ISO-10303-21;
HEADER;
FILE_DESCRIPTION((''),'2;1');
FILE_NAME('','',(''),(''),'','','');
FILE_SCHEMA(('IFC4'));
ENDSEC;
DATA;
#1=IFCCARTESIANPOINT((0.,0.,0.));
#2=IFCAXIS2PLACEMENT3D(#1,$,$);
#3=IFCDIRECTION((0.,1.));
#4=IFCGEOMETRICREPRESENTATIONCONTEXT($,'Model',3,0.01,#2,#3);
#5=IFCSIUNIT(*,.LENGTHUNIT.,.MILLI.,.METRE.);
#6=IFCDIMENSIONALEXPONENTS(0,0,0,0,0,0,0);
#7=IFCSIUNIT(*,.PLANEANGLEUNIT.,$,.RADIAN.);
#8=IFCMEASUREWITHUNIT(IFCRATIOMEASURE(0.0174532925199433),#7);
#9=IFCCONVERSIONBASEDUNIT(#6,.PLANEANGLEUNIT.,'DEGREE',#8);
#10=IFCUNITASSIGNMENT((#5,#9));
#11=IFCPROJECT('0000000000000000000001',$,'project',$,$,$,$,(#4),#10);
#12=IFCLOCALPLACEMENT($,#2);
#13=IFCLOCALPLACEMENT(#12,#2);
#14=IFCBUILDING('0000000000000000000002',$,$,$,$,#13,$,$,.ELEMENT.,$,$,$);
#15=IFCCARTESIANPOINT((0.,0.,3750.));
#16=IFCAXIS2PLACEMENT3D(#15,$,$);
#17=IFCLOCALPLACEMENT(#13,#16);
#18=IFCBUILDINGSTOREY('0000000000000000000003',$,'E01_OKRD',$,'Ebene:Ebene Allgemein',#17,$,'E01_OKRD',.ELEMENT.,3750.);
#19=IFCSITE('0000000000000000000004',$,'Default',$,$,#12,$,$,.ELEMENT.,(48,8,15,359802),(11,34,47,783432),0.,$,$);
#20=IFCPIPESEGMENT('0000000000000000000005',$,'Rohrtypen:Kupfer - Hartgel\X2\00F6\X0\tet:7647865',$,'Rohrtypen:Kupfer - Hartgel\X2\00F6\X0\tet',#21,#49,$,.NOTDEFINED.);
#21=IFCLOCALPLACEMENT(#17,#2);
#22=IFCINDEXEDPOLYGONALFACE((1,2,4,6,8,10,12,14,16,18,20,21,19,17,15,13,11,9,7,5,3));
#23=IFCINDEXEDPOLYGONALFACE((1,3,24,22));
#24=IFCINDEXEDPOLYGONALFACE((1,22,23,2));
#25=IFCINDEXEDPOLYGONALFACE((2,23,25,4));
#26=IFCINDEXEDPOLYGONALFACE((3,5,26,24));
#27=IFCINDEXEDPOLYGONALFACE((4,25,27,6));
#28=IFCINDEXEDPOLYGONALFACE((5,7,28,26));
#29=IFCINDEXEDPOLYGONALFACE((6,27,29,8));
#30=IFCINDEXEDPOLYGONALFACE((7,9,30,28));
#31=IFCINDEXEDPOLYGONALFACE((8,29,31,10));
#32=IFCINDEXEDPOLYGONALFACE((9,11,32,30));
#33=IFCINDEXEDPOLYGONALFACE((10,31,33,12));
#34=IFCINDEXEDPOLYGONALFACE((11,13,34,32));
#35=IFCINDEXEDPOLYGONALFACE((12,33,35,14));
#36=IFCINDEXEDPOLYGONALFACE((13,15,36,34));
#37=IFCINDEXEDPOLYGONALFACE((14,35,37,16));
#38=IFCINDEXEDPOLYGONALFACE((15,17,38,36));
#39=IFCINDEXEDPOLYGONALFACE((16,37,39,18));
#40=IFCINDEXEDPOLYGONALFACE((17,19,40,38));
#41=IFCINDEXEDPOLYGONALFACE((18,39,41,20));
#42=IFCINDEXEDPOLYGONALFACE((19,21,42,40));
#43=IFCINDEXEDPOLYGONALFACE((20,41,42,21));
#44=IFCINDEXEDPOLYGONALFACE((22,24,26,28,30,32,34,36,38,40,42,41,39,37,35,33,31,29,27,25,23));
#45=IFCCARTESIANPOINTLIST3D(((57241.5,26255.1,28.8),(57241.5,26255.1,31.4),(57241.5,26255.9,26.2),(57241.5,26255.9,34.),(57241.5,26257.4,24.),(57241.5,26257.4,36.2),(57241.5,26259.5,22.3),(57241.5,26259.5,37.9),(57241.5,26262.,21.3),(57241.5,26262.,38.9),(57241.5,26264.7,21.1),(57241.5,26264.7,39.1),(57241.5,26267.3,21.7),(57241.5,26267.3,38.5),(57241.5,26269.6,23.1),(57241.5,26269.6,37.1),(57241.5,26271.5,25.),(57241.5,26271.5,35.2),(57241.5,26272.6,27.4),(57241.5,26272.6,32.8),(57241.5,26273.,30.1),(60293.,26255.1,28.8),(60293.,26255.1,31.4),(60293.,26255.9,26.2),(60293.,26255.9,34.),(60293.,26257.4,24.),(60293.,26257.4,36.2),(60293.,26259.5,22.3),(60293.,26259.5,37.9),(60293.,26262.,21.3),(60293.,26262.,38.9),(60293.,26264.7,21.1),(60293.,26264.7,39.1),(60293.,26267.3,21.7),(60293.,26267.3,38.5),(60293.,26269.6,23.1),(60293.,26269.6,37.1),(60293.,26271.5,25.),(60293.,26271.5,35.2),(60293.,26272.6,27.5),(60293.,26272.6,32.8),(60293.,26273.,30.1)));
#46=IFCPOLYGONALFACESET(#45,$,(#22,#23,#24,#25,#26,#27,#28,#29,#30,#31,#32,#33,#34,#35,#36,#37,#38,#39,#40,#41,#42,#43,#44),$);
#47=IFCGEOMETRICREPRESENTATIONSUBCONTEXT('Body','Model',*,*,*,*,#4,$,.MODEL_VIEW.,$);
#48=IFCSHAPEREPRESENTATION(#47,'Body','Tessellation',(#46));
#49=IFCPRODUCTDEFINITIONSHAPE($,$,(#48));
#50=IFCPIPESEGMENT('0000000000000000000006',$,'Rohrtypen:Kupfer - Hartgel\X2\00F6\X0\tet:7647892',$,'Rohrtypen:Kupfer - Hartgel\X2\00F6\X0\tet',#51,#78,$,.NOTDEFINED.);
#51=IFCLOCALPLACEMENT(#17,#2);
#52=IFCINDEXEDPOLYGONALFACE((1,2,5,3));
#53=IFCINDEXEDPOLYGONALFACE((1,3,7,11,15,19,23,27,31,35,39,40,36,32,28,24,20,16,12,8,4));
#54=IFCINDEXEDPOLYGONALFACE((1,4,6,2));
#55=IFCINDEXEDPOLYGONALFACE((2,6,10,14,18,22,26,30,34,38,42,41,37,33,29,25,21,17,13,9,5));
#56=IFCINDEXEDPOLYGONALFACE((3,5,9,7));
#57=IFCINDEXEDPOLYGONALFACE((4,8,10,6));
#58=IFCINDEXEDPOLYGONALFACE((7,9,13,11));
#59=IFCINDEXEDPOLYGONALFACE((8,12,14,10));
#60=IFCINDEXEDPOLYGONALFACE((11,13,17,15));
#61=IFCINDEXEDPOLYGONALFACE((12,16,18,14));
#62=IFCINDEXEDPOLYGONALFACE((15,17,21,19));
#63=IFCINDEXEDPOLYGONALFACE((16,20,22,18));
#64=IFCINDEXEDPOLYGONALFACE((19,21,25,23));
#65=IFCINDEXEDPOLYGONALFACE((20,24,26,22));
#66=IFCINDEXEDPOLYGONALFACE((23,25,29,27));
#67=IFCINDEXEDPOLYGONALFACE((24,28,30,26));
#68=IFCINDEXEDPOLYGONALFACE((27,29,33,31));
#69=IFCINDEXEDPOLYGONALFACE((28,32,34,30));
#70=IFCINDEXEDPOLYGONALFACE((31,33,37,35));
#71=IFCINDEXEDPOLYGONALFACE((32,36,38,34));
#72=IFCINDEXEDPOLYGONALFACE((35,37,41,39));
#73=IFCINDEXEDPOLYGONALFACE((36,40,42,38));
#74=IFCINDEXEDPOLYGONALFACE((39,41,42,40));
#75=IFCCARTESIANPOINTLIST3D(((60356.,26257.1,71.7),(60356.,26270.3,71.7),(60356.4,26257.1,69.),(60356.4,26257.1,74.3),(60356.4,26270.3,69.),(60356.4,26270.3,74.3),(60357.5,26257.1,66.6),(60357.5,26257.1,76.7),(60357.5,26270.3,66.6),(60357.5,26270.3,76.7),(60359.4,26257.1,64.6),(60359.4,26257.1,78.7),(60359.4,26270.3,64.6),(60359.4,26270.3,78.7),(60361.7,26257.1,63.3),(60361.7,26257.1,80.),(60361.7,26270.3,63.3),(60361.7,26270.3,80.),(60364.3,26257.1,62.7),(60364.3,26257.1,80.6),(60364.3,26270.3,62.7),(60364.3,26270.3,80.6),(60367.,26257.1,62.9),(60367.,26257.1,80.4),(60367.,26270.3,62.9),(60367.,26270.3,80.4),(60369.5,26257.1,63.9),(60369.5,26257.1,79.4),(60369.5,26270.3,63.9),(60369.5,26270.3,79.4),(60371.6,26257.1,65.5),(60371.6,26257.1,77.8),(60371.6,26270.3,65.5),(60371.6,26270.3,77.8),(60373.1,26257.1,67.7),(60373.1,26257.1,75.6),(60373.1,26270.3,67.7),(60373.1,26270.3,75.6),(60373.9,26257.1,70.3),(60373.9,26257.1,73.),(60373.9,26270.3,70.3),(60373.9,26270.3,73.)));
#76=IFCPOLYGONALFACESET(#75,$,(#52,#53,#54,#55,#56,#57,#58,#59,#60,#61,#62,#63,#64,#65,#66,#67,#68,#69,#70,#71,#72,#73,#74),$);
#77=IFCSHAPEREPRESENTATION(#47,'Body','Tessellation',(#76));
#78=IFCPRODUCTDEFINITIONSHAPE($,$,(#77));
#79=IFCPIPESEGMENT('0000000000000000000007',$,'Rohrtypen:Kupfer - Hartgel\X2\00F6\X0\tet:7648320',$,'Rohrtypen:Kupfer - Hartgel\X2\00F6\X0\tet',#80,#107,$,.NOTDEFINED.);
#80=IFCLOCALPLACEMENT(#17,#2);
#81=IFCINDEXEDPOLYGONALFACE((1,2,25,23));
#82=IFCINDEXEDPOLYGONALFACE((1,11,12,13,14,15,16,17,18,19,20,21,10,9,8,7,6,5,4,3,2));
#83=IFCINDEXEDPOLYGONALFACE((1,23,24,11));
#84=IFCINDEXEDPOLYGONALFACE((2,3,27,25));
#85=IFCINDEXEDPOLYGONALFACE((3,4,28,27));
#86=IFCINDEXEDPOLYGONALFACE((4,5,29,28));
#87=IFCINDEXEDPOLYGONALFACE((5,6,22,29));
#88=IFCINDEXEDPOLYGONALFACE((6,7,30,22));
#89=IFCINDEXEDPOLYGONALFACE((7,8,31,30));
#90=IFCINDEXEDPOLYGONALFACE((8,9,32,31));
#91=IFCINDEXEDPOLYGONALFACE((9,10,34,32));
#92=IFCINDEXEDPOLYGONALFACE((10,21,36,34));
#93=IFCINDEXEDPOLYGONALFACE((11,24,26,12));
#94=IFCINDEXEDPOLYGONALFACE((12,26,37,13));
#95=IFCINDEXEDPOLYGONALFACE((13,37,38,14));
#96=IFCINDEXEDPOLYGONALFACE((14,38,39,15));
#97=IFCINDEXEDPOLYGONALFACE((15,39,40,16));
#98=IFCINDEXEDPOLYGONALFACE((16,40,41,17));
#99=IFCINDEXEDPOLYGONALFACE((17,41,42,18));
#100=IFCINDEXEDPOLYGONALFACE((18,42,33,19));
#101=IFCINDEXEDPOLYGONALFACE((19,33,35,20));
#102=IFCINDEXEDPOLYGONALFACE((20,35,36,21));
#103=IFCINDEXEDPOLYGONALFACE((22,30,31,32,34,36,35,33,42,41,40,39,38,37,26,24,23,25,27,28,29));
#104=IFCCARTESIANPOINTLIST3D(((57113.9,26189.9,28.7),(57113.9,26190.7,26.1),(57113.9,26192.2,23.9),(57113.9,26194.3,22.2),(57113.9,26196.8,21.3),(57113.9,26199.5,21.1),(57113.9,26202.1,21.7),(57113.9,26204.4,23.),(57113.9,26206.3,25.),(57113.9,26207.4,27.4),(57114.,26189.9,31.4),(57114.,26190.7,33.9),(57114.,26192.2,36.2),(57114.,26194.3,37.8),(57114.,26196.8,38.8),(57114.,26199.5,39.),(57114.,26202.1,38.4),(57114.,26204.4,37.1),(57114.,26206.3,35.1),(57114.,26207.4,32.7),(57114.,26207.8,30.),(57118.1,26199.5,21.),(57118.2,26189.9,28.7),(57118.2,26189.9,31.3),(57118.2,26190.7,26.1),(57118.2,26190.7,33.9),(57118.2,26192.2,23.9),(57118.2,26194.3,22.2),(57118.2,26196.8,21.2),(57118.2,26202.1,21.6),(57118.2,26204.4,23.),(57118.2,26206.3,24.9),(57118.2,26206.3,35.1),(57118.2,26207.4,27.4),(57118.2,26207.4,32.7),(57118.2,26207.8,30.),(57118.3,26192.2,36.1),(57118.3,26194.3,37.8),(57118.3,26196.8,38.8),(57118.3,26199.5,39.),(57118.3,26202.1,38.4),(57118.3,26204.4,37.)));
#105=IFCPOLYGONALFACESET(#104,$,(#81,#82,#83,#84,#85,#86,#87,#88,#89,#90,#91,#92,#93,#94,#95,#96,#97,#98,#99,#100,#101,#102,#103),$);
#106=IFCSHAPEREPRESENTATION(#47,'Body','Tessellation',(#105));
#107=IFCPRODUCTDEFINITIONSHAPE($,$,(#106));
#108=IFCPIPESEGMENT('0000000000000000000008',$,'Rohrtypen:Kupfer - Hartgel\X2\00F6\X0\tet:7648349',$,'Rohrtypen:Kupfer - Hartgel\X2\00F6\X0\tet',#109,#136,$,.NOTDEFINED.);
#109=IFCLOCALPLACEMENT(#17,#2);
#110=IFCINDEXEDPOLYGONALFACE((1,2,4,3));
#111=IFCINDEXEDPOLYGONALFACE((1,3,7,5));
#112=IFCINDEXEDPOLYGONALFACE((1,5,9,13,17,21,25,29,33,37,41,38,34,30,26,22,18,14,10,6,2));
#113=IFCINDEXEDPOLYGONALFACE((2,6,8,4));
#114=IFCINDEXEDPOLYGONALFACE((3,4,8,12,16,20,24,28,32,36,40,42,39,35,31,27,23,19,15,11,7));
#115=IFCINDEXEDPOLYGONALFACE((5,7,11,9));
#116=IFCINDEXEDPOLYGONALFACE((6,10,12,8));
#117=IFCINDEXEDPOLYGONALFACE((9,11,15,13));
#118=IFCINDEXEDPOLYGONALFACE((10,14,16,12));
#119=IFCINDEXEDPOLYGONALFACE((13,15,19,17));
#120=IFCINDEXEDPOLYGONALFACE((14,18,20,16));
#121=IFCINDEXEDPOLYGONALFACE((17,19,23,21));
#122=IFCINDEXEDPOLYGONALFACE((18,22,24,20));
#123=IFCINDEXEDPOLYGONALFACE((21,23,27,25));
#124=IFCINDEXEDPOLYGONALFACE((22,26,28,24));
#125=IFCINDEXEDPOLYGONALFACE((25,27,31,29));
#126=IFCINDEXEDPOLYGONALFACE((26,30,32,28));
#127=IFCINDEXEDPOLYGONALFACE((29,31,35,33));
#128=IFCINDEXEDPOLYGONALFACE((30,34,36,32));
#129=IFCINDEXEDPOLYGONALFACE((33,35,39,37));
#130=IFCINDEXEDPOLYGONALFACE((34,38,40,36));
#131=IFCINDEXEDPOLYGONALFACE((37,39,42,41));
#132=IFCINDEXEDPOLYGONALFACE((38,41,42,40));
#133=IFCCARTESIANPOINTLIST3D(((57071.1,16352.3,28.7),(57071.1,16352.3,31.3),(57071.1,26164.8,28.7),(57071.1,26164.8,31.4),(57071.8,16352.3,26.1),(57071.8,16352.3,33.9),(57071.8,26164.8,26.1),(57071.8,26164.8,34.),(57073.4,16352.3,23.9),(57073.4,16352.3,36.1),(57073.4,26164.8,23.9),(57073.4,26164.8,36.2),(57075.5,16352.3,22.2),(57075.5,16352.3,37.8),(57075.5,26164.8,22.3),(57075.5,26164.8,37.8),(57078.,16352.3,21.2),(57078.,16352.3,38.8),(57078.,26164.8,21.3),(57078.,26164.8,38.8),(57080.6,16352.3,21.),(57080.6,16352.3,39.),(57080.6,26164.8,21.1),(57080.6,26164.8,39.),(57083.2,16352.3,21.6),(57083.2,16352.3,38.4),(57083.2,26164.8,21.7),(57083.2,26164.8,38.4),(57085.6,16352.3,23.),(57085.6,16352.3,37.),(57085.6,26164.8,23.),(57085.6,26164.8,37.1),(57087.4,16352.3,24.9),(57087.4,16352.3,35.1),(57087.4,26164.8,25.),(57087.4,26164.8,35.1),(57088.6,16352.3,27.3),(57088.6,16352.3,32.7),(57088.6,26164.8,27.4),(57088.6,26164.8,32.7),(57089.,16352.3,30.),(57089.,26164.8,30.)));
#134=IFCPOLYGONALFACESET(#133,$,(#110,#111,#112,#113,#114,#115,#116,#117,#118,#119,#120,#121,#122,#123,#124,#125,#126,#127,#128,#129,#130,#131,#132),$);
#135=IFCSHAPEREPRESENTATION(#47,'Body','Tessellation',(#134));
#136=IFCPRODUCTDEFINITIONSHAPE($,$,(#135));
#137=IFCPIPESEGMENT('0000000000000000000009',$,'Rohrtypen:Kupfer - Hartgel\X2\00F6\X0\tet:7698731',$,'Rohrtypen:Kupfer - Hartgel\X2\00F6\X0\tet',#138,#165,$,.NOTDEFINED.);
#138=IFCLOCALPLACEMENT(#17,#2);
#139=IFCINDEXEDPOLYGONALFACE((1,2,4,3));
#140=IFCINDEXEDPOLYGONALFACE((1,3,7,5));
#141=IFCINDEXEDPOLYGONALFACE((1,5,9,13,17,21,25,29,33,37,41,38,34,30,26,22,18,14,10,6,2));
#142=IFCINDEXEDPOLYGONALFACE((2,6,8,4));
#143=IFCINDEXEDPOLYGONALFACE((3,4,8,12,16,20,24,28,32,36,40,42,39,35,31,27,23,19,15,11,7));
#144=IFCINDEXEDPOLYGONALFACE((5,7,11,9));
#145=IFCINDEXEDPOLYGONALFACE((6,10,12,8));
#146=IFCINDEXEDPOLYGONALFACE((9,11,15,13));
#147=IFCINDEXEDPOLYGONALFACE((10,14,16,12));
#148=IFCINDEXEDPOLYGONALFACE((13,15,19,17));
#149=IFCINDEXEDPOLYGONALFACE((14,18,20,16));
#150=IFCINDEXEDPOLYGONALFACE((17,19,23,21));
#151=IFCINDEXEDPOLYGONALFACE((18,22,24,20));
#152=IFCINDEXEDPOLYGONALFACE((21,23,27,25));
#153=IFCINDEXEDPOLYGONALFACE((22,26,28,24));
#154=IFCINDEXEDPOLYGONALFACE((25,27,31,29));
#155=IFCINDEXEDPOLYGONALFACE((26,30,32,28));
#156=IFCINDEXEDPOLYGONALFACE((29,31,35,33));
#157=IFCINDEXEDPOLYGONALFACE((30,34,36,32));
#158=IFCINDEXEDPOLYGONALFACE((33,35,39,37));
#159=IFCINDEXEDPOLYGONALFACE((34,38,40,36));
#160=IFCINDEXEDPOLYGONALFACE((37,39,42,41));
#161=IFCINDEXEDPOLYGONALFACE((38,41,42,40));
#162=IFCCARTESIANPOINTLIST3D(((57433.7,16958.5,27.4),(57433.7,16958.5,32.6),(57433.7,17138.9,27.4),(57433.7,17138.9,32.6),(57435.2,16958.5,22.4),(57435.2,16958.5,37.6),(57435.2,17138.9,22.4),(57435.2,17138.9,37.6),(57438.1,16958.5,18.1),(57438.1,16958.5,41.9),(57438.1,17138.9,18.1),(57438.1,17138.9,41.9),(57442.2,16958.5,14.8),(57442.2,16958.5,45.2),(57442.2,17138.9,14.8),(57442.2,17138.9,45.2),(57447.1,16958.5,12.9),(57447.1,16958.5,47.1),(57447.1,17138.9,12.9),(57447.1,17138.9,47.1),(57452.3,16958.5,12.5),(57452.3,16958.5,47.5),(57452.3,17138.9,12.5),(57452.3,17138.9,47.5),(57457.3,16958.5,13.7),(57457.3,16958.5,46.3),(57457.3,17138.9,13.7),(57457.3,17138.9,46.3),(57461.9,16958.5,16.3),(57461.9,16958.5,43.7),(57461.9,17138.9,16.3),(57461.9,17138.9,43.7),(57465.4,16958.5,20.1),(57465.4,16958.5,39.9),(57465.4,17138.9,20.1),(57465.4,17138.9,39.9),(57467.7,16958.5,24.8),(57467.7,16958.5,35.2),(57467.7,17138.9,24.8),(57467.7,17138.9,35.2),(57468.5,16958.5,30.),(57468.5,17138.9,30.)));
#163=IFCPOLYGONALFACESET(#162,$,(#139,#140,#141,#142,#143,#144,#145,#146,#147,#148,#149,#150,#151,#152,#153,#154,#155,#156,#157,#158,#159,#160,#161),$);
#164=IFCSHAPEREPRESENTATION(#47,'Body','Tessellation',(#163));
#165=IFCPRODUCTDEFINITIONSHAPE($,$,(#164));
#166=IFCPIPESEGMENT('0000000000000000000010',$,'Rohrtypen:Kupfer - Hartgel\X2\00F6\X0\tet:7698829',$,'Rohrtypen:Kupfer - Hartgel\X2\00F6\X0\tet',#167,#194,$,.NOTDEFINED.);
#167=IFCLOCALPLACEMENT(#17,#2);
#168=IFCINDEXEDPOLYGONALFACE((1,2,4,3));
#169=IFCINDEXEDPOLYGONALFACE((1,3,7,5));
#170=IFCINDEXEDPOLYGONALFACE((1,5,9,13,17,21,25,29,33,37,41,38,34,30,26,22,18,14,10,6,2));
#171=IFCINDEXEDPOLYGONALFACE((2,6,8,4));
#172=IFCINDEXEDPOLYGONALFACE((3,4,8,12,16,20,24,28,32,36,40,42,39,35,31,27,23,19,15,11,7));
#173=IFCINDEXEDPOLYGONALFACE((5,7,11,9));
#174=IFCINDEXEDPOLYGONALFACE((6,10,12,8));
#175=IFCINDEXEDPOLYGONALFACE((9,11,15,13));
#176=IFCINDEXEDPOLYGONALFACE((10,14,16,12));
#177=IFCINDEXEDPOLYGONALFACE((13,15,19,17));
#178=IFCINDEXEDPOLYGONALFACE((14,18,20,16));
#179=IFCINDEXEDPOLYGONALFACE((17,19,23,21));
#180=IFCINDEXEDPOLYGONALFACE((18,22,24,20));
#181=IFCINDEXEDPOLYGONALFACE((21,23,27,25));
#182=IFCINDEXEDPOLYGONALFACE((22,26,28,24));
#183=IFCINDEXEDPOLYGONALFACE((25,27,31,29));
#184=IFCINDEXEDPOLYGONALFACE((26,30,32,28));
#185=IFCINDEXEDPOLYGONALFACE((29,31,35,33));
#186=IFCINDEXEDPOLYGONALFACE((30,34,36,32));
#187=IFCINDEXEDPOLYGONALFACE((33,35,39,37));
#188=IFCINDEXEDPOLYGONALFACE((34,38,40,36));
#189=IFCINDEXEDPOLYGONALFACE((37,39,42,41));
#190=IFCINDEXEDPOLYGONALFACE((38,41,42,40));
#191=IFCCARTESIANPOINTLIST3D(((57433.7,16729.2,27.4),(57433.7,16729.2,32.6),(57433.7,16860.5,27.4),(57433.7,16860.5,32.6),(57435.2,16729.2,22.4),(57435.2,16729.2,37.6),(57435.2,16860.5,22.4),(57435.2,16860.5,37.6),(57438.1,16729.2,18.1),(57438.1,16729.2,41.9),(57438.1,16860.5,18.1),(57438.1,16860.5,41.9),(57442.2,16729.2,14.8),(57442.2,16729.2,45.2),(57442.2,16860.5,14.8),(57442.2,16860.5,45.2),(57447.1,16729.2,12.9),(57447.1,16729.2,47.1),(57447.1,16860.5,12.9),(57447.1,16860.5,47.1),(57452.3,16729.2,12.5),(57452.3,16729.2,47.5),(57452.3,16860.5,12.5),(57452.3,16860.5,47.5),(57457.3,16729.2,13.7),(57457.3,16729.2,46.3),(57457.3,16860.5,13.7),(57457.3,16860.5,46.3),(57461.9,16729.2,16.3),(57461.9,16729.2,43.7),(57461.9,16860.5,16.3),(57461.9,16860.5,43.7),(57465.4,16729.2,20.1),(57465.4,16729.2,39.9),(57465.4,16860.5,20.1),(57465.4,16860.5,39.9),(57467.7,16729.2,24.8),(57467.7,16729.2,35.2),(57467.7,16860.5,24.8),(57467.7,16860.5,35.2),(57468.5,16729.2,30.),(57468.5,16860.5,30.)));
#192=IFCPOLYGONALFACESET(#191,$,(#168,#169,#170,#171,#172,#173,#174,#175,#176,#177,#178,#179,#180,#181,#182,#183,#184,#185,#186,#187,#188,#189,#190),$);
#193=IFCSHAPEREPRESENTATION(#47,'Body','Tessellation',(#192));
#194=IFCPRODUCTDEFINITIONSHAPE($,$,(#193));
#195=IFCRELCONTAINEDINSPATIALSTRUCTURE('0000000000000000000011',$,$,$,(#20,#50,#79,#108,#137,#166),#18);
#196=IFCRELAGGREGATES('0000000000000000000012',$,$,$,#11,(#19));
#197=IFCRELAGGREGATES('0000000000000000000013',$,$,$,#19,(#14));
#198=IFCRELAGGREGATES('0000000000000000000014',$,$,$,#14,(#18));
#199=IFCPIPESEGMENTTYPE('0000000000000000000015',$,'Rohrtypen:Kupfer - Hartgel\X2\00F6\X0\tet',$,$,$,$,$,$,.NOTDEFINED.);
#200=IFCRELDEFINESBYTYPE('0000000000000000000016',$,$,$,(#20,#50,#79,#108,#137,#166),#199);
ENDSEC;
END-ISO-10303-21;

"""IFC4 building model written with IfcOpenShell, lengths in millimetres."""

from ifc_helpers import new_model, entity, si_unit, converted_unit, direction, frame, frame_2d, origin, origin_2d_with_axis, place, context, subcontext, project, spatial, circle, extrude, type_object, element, save


model = new_model("IFC4")

# Units and contexts
model_context = context("Model", 3, precision=0.01, world=origin(), true_north=direction((0.0, 1.0)))
body_context = subcontext(model_context, "Body", "Model", "MODEL_VIEW")
ifc_project = project(units=[si_unit("LENGTHUNIT", "METRE", prefix="MILLI"), converted_unit("PLANEANGLEUNIT", "DEGREE", entity("IfcRatioMeasure", 0.0174532925199433), si_unit("PLANEANGLEUNIT", "RADIAN"), dimensions=[0, 0, 0, 0, 0, 0, 0])], contexts=[model_context])

# Site, building, storey
site_placement = place(None, origin())
site = spatial("IfcSite", under=ifc_project, at=site_placement, Name="Default", CompositionType="ELEMENT", RefLatitude=(48, 8, 15, 359802), RefLongitude=(11, 34, 47, 783432), RefElevation=0.0)
building_placement = place(site_placement, origin())
building = spatial("IfcBuilding", under=site, at=building_placement, CompositionType="ELEMENT")
storey_placement = place(building_placement, frame((0.0, 0.0, 3750.0)))
storey = spatial("IfcBuildingStorey", under=building, at=storey_placement, Name="E01_OKRD", ObjectType="Ebene:Ebene Allgemein", LongName="E01_OKRD", CompositionType="ELEMENT", Elevation=3750.0)

# Pipe segments
pipe_segment_type = type_object("IfcPipeSegmentType", Name="Rohrtypen:Kupfer - Hartgelötet", PredefinedType="NOTDEFINED")
pipe_segment_1_placement = place(storey_placement, frame((57241.5, 26253.4, 19.5)))
element("IfcPipeSegment", 1, at=pipe_segment_1_placement, inside=storey, type_object=pipe_segment_type, Name="Rohrtypen:Kupfer - Hartgelötet:7647865", ObjectType="Rohrtypen:Kupfer - Hartgelötet", PredefinedType="NOTDEFINED", context=body_context, shape_type="SweptSolid", body=[
    extrude(circle(Radius=9.0, at=origin_2d_with_axis()), frame((0.0, 10.6, 10.6), z_axis=(1.0, 0.0, 0.000002), x_axis=(0.0, 1.0, 0.0)), (0.0, 0.0, 1.0), 3051.5),
])
pipe_segment_2_placement = place(storey_placement, frame((60354.4, 26257.1, 61.1)))
element("IfcPipeSegment", 2, at=pipe_segment_2_placement, inside=storey, type_object=pipe_segment_type, Name="Rohrtypen:Kupfer - Hartgelötet:7647892", ObjectType="Rohrtypen:Kupfer - Hartgelötet", PredefinedType="NOTDEFINED", context=body_context, shape_type="SweptSolid", body=[
    extrude(circle(Radius=9.0, at=frame_2d((0.0, 0.0), x_axis=(1.0, 0.0))), frame((10.6, 0.0, 10.6), z_axis=(0.000023, 1.0, 0.000272), x_axis=(-1.0, 0.000023, 0.0)), (0.0, 0.0, 1.0), 13.2),
])
pipe_segment_3_placement = place(storey_placement, frame((57113.9, 26188.2, 19.4)))
element("IfcPipeSegment", 3, at=pipe_segment_3_placement, inside=storey, type_object=pipe_segment_type, Name="Rohrtypen:Kupfer - Hartgelötet:7648320", ObjectType="Rohrtypen:Kupfer - Hartgelötet", PredefinedType="NOTDEFINED", context=body_context, shape_type="SweptSolid", body=[
    extrude(circle(Radius=9.0, at=origin_2d_with_axis()), frame((4.3, 10.6, 10.6), z_axis=(-0.999976, 0.0, 0.006947), x_axis=(0.0, 1.0, 0.0)), (0.0, 0.0, 1.0), 4.3),
])
pipe_segment_4_placement = place(storey_placement, frame((57069.4, 16352.3, 19.4)))
element("IfcPipeSegment", 4, at=pipe_segment_4_placement, inside=storey, type_object=pipe_segment_type, Name="Rohrtypen:Kupfer - Hartgelötet:7648349", ObjectType="Rohrtypen:Kupfer - Hartgelötet", PredefinedType="NOTDEFINED", context=body_context, shape_type="SweptSolid", body=[
    extrude(circle(Radius=9.0, at=frame_2d((0.0, 0.0), x_axis=(1.0, 0.0))), frame((10.6, 0.0, 10.6), z_axis=(0.0, 1.0, 0.000005), x_axis=(1.0, 0.0, 0.0)), (0.0, 0.0, 1.0), 9812.5),
])
pipe_segment_5_placement = place(storey_placement, frame((57431.9, 16958.5, 10.9)))
element("IfcPipeSegment", 5, at=pipe_segment_5_placement, inside=storey, type_object=pipe_segment_type, Name="Rohrtypen:Kupfer - Hartgelötet:7698731", ObjectType="Rohrtypen:Kupfer - Hartgelötet", PredefinedType="NOTDEFINED", context=body_context, shape_type="SweptSolid", body=[
    extrude(circle(Radius=17.5, at=frame_2d((0.0, 0.0), x_axis=(1.0, 0.0))), frame((19.1, 0.0, 19.1), z_axis=(0.0, 1.0, 0.0), x_axis=(1.0, 0.0, 0.0)), (0.0, 0.0, 1.0), 180.3),
])
pipe_segment_6_placement = place(storey_placement, frame((57431.9, 16729.2, 10.9)))
element("IfcPipeSegment", 6, at=pipe_segment_6_placement, inside=storey, type_object=pipe_segment_type, Name="Rohrtypen:Kupfer - Hartgelötet:7698829", ObjectType="Rohrtypen:Kupfer - Hartgelötet", PredefinedType="NOTDEFINED", context=body_context, shape_type="SweptSolid", body=[
    extrude(circle(Radius=17.5, at=origin_2d_with_axis()), frame((19.1, 0.0, 19.1), z_axis=(0.0, 1.0, 0.0), x_axis=(1.0, 0.0, 0.0)), (0.0, 0.0, 1.0), 131.3),
])

save(model, "model.ifc")
